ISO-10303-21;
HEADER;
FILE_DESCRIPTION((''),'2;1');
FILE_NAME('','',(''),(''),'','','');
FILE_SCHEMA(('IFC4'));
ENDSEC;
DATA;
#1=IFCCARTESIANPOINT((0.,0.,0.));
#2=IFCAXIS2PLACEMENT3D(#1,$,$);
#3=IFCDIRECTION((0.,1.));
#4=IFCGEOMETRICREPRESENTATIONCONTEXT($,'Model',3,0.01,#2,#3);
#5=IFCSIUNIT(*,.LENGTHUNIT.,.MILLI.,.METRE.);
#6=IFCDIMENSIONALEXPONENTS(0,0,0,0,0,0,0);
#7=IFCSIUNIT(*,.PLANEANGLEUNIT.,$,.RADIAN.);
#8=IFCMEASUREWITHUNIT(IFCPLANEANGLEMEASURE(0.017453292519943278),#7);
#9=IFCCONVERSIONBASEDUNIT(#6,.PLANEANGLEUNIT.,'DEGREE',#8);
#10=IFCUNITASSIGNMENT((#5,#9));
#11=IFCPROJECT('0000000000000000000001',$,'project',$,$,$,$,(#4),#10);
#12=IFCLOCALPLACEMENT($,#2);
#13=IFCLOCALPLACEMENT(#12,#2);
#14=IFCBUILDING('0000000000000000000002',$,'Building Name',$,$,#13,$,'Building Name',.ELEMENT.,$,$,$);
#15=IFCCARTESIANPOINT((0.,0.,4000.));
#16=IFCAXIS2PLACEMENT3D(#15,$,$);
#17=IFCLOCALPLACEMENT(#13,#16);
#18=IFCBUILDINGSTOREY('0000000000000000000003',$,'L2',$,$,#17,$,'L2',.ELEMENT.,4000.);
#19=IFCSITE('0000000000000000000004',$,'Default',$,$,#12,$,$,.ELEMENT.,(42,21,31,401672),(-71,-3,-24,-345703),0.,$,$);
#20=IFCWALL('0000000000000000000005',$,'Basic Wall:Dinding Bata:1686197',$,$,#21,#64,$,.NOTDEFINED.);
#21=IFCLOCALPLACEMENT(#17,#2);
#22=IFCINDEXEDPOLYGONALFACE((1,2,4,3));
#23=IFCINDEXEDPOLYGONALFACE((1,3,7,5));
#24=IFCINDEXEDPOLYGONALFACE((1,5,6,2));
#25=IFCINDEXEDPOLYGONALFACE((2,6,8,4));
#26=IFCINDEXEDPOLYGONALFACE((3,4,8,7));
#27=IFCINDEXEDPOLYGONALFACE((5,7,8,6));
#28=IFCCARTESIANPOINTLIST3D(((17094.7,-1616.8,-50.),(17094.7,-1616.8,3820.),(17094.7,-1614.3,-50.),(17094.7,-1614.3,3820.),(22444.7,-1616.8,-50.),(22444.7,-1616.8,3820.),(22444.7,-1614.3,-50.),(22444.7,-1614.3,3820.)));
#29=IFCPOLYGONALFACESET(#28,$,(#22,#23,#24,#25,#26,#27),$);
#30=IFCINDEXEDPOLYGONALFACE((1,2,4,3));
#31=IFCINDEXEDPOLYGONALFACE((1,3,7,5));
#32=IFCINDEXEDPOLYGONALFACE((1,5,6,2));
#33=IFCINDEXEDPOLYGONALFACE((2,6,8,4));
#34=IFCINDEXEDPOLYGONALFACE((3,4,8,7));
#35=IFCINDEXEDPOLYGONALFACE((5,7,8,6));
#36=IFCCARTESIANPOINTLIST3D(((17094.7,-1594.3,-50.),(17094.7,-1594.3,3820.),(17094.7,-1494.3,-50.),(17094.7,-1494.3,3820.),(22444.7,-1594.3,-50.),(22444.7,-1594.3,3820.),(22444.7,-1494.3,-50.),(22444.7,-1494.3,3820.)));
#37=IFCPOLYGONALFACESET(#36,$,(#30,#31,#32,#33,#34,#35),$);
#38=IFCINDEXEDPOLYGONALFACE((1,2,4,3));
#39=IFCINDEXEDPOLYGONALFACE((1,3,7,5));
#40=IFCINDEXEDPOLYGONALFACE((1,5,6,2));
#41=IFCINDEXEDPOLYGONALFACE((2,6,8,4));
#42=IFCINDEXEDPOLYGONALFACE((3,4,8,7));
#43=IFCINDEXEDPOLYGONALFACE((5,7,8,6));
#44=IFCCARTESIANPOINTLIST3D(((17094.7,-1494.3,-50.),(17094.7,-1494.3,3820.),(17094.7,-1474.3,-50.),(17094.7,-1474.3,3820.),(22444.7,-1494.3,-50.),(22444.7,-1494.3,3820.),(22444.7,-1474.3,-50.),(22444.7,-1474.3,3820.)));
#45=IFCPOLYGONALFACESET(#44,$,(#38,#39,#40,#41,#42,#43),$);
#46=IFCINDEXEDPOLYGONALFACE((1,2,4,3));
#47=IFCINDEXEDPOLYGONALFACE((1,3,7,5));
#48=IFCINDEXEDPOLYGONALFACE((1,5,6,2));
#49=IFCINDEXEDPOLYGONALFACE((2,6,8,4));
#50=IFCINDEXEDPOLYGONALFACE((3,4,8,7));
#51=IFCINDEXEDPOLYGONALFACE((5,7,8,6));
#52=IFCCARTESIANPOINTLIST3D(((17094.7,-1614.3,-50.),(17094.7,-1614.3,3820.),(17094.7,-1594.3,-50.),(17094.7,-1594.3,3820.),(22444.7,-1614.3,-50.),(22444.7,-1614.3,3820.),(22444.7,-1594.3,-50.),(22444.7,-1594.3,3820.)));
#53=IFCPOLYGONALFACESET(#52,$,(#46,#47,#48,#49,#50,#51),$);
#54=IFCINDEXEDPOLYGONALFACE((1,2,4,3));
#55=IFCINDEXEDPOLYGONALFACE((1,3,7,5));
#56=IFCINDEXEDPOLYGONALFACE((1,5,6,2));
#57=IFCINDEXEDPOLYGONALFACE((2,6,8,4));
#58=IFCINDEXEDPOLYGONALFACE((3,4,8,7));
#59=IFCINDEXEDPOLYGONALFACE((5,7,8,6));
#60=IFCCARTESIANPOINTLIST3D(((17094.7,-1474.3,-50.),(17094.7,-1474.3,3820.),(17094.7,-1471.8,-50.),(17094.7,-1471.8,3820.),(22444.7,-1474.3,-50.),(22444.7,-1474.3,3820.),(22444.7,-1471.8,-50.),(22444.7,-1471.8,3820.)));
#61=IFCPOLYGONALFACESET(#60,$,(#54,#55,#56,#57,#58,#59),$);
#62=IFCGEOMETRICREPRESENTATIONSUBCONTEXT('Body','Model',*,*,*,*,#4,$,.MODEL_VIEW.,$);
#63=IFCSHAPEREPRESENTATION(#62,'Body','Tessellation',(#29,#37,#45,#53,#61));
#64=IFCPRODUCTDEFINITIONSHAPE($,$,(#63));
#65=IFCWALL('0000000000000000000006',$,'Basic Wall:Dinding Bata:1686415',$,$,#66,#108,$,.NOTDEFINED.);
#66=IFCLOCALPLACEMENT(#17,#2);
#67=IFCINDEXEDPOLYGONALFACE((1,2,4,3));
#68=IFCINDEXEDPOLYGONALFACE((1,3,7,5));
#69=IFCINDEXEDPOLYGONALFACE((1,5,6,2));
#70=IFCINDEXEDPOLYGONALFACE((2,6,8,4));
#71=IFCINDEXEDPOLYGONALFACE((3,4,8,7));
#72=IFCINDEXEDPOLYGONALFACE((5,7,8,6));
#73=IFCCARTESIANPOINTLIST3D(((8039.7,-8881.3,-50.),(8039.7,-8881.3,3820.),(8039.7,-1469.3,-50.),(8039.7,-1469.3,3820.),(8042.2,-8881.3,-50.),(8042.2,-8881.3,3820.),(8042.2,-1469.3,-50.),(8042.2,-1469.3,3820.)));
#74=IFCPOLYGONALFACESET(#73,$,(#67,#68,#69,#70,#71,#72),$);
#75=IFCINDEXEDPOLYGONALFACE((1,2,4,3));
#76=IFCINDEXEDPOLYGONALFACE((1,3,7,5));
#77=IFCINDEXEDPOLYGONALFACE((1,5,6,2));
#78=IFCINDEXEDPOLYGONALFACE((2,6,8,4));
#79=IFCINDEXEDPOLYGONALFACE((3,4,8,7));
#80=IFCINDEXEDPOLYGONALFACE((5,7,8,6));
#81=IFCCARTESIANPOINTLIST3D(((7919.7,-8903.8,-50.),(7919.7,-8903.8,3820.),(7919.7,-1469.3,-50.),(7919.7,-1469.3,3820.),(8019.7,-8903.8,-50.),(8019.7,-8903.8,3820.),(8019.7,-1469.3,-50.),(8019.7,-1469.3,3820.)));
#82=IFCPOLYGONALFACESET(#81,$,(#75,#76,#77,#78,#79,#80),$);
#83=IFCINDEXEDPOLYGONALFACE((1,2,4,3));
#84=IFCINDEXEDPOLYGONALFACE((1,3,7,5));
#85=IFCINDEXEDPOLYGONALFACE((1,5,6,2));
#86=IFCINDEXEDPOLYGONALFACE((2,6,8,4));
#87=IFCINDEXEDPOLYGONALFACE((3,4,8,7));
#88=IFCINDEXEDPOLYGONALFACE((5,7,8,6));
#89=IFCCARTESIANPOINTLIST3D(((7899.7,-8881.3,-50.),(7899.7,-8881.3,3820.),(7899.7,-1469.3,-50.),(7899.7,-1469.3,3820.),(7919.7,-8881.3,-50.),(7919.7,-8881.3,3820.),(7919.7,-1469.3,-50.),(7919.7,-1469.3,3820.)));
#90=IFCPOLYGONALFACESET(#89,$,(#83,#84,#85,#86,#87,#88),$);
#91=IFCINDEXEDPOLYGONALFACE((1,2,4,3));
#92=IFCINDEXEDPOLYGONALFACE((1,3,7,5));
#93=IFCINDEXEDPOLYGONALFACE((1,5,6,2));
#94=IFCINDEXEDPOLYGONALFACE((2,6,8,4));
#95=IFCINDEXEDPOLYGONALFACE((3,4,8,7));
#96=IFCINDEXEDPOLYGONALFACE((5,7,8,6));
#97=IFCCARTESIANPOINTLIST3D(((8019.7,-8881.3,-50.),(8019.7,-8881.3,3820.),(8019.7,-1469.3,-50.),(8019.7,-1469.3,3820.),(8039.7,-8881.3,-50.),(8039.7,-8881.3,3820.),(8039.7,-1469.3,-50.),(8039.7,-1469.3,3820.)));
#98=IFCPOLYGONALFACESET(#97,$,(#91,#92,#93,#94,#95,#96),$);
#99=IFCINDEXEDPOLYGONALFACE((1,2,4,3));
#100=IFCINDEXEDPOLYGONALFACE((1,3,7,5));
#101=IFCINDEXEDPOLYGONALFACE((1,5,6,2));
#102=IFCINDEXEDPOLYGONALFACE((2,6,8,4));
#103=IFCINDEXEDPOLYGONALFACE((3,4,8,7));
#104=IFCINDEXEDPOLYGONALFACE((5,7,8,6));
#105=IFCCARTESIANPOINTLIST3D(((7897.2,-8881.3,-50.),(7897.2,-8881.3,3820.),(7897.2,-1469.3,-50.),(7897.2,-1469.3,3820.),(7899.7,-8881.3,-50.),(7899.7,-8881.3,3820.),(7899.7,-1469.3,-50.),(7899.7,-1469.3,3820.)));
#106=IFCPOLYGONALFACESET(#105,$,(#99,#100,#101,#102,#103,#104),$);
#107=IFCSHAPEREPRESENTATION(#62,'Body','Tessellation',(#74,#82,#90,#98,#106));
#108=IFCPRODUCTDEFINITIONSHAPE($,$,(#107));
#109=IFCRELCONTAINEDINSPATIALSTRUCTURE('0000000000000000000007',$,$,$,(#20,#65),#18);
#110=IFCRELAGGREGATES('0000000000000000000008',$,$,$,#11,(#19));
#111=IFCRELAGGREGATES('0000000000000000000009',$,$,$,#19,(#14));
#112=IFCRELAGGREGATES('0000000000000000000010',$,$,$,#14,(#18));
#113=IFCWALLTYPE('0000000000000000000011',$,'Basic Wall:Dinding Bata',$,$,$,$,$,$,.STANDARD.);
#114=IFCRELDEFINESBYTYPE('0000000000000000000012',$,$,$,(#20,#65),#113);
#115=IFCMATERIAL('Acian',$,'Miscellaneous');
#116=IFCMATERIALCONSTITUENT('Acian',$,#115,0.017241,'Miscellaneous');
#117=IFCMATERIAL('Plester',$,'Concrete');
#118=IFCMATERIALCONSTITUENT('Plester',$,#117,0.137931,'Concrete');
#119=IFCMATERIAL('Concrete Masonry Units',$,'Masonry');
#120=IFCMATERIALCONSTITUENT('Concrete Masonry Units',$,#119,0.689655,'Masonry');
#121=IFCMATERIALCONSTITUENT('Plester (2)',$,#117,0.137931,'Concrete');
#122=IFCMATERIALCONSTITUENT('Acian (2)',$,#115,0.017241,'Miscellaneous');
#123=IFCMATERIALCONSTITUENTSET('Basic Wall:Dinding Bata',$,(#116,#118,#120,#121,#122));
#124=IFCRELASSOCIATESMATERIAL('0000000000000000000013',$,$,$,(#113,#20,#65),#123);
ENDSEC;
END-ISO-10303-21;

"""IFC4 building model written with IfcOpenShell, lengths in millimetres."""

from ifc_helpers import new_model, entity, si_unit, converted_unit, direction, frame, origin, place, context, subcontext, project, spatial, indexed_curve, outline, extrude, material, constituent, constituent_set, type_object, element, save


model = new_model("IFC4")

# Units and contexts
model_context = context("Model", 3, precision=0.01, world=origin(), true_north=direction((0.0, 1.0)))
body_context = subcontext(model_context, "Body", "Model", "MODEL_VIEW")
ifc_project = project(units=[si_unit("LENGTHUNIT", "METRE", prefix="MILLI"), converted_unit("PLANEANGLEUNIT", "DEGREE", entity("IfcPlaneAngleMeasure", 0.017453292519943278), si_unit("PLANEANGLEUNIT", "RADIAN"), dimensions=[0, 0, 0, 0, 0, 0, 0])], contexts=[model_context])

# Site, building, storey
site_placement = place(None, origin())
site = spatial("IfcSite", under=ifc_project, at=site_placement, Name="Default", CompositionType="ELEMENT", RefLatitude=(42, 21, 31, 401672), RefLongitude=(-71, -3, -24, -345703), RefElevation=0.0)
building_placement = place(site_placement, origin())
building = spatial("IfcBuilding", under=site, at=building_placement, Name="Building Name", LongName="Building Name", CompositionType="ELEMENT")
storey_placement = place(building_placement, frame((0.0, 0.0, 4000.0)))
storey = spatial("IfcBuildingStorey", under=building, at=storey_placement, Name="L2", LongName="L2", CompositionType="ELEMENT", Elevation=4000.0)

# Walls
ifc_material_1 = material(Name="Acian", Category="Miscellaneous")
ifc_constituent_1 = constituent(ifc_material_1, Name="Acian", Category="Miscellaneous", fraction=0.017241)
ifc_material_2 = material(Name="Plester", Category="Concrete")
ifc_constituent_2 = constituent(ifc_material_2, Name="Plester", Category="Concrete", fraction=0.137931)
ifc_material_3 = material(Name="Concrete Masonry Units", Category="Masonry")
ifc_constituent_3 = constituent(ifc_material_3, Name="Concrete Masonry Units", Category="Masonry", fraction=0.689655)
ifc_constituent_4 = constituent(ifc_material_2, Name="Plester (2)", Category="Concrete", fraction=0.137931)
ifc_constituent_5 = constituent(ifc_material_1, Name="Acian (2)", Category="Miscellaneous", fraction=0.017241)
ifc_constituent_set = constituent_set(constituents=[ifc_constituent_1, ifc_constituent_2, ifc_constituent_3, ifc_constituent_4, ifc_constituent_5], Name="Basic Wall:Dinding Bata")
wall_type = type_object("IfcWallType", Name="Basic Wall:Dinding Bata", PredefinedType="STANDARD", material=ifc_constituent_set)
wall_1_placement = place(storey_placement, frame((22444.7, -1544.3, -50.0), z_axis=(0.0, 0.0, 1.0), x_axis=(-1.0, 0.0, 0.0)))
element("IfcWall", 1, at=wall_1_placement, inside=storey, type_object=wall_type, material=ifc_constituent_set, Name="Basic Wall:Dinding Bata:1686197", PredefinedType="NOTDEFINED", context=body_context, shape_type="SweptSolid", body=[
    extrude(outline(indexed_curve([(-1.3, -2675.0), (1.2, -2675.0), (1.3, 2675.0), (-1.2, 2675.0), (-1.3, -2675.0)], self_intersect=False)), frame((2675.0, 71.3, 0.0), z_axis=(0.0, 0.0, 1.0), x_axis=(0.0, -1.0, 0.0)), (0.0, 0.0, 1.0), 3870.0),
    extrude(outline(indexed_curve([(-2675.0, -50.0), (2675.0, -50.0), (2675.0, 50.0), (-2675.0, 50.0), (-2675.0, -50.0)], self_intersect=False)), frame((2675.0, 0.0, 0.0)), (0.0, 0.0, 1.0), 3870.0),
    extrude(outline(indexed_curve([(-2675.0, -10.0), (2675.0, -10.0), (2675.0, 10.0), (-2675.0, 10.0), (-2675.0, -10.0)], self_intersect=False)), frame((2675.0, -60.0, 0.0)), (0.0, 0.0, 1.0), 3870.0),
    extrude(outline(indexed_curve([(-2675.0, -10.0), (2675.0, -10.0), (2675.0, 10.0), (-2675.0, 10.0), (-2675.0, -10.0)], self_intersect=False)), frame((2675.0, 60.0, 0.0)), (0.0, 0.0, 1.0), 3870.0),
    extrude(outline(indexed_curve([(-1.3, -2675.0), (1.2, -2675.0), (1.3, 2675.0), (-1.2, 2675.0), (-1.3, -2675.0)], self_intersect=False)), frame((2675.0, -71.3, 0.0), z_axis=(0.0, 0.0, 1.0), x_axis=(0.0, 1.0, 0.0)), (0.0, 0.0, 1.0), 3870.0),
])
wall_2_placement = place(storey_placement, frame((7969.7, -1469.3, -50.0), z_axis=(0.0, 0.0, 1.0), x_axis=(0.0, -1.0, 0.0)))
element("IfcWall", 2, at=wall_2_placement, inside=storey, type_object=wall_type, material=ifc_constituent_set, Name="Basic Wall:Dinding Bata:1686415", PredefinedType="NOTDEFINED", context=body_context, shape_type="SweptSolid", body=[
    extrude(outline(indexed_curve([(-1.3, -3706.0), (1.2, -3706.0), (1.3, 3706.0), (-1.2, 3706.0), (-1.3, -3706.0)], self_intersect=False)), frame((3706.0, 71.3, 0.0), z_axis=(0.0, 0.0, 1.0), x_axis=(0.0, -1.0, 0.0)), (0.0, 0.0, 1.0), 3870.0),
    extrude(outline(indexed_curve([(-3717.3, -50.0), (3717.3, -50.0), (3717.3, 50.0), (-3717.3, 50.0), (-3717.3, -50.0)], self_intersect=False)), frame((3717.3, 0.0, 0.0)), (0.0, 0.0, 1.0), 3870.0),
    extrude(outline(indexed_curve([(-3706.0, -10.0), (3706.0, -10.0), (3706.0, 10.0), (-3706.0, 10.0), (-3706.0, -10.0)], self_intersect=False)), frame((3706.0, -60.0, 0.0)), (0.0, 0.0, 1.0), 3870.0),
    extrude(outline(indexed_curve([(-3706.0, -10.0), (3706.0, -10.0), (3706.0, 10.0), (-3706.0, 10.0), (-3706.0, -10.0)], self_intersect=False)), frame((3706.0, 60.0, 0.0)), (0.0, 0.0, 1.0), 3870.0),
    extrude(outline(indexed_curve([(-1.3, -3706.0), (1.2, -3706.0), (1.3, 3706.0), (-1.2, 3706.0), (-1.3, -3706.0)], self_intersect=False)), frame((3706.0, -71.2, 0.0), z_axis=(0.0, 0.0, 1.0), x_axis=(0.0, 1.0, 0.0)), (0.0, 0.0, 1.0), 3870.0),
])

save(model, "model.ifc")
